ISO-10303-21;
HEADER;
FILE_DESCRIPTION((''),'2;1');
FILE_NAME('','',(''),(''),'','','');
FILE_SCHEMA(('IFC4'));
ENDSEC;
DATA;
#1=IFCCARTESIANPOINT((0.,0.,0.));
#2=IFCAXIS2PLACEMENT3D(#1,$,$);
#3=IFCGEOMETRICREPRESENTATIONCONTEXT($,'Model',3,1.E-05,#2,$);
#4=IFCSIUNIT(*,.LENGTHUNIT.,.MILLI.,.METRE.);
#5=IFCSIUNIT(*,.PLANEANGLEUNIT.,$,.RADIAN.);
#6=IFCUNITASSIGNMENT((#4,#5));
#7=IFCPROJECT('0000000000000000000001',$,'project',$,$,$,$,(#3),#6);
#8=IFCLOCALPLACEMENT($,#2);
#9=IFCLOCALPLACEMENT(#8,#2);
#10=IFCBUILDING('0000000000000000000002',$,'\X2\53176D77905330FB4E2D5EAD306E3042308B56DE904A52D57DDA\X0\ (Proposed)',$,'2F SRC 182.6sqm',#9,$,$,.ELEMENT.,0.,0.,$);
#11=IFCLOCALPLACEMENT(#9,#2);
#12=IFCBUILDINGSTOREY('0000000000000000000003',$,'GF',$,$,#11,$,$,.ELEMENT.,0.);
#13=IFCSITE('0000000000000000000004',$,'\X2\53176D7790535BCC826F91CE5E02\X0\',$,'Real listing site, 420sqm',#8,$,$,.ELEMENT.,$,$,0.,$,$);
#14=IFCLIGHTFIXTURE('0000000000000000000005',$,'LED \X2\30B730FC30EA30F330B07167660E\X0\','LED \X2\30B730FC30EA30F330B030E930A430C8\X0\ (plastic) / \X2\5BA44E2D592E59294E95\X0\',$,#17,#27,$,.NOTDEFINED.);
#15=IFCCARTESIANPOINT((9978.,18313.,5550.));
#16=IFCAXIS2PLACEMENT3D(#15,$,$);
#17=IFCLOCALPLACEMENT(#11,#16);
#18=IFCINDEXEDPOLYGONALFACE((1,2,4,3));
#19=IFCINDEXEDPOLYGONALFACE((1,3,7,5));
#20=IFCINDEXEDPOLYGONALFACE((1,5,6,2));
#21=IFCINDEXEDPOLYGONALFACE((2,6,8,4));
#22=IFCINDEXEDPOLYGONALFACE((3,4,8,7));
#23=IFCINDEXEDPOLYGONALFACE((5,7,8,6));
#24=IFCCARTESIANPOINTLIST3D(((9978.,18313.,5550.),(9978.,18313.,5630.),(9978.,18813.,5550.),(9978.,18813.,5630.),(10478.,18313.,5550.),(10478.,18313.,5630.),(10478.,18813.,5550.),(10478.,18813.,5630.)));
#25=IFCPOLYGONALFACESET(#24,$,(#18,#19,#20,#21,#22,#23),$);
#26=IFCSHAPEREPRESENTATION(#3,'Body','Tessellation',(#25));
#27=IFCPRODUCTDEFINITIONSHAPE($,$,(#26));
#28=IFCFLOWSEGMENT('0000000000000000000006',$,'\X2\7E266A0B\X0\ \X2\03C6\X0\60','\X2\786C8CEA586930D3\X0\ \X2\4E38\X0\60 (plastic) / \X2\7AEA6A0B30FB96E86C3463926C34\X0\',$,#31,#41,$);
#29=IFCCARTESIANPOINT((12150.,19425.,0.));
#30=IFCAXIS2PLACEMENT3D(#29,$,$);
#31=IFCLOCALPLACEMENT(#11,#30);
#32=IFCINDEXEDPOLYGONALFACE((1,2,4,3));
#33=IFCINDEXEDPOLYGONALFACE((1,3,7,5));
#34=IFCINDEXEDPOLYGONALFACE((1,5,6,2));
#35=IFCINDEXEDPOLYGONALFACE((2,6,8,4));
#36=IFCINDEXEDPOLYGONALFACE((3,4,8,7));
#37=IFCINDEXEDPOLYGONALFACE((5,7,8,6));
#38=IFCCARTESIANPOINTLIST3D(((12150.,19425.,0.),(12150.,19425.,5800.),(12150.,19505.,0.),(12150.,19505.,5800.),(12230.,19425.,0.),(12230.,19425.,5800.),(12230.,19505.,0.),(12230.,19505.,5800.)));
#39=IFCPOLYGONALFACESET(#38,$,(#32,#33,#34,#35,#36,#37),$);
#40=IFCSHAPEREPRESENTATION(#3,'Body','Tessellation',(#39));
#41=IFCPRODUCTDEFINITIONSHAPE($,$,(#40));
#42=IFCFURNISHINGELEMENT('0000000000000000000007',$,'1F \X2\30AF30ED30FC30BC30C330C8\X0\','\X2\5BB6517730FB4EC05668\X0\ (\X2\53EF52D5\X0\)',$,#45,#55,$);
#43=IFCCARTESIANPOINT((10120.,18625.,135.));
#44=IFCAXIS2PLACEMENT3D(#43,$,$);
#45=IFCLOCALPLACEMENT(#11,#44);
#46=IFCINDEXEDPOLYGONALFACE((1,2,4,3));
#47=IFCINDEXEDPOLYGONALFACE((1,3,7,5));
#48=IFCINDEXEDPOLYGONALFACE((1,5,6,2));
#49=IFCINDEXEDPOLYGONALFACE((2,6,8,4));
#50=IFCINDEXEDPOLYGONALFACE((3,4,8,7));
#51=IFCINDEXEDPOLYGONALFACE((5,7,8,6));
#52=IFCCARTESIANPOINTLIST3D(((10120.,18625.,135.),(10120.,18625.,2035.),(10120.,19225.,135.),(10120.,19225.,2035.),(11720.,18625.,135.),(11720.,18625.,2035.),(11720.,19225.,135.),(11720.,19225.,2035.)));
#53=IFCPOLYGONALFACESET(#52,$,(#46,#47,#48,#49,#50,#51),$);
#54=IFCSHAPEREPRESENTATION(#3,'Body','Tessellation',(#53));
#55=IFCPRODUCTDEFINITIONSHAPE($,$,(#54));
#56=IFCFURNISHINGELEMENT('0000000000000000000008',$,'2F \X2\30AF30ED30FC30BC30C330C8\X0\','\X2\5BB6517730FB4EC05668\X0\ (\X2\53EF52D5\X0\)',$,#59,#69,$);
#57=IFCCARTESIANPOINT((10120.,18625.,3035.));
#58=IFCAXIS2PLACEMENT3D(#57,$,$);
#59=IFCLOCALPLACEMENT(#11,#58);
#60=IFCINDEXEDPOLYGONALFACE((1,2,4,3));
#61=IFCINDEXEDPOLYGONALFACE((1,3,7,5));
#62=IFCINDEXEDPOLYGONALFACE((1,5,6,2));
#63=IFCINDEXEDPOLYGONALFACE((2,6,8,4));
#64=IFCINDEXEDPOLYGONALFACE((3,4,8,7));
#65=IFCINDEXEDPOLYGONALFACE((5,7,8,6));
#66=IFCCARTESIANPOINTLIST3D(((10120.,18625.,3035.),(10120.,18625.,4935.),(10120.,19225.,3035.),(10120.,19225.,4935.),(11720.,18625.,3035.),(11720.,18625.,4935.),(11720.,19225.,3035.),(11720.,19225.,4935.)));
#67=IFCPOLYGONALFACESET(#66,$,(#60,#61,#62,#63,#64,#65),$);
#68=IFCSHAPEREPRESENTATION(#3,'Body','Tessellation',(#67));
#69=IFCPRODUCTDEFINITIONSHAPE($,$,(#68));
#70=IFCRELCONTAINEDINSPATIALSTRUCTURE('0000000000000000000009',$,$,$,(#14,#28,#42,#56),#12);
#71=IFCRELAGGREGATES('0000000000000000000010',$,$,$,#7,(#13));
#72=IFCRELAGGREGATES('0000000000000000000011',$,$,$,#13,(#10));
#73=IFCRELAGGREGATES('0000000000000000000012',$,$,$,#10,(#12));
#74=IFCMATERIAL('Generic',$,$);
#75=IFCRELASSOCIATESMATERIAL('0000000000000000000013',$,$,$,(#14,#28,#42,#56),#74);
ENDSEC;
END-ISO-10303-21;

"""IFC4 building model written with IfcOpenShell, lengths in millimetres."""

from ifc_helpers import new_model, si_unit, frame, frame_2d, origin, place, context, project, spatial, rectangle, extrude, material, element, save


model = new_model("IFC4")

# Units and contexts
model_context = context("Model", 3, precision=1e-05, world=origin())
ifc_project = project(units=[si_unit("LENGTHUNIT", "METRE", prefix="MILLI"), si_unit("PLANEANGLEUNIT", "RADIAN")], contexts=[model_context])

# Site, building, storey
site_placement = place(None, origin())
site = spatial("IfcSite", under=ifc_project, at=site_placement, Name="北海道富良野市", ObjectType="Real listing site, 420sqm", CompositionType="ELEMENT", RefElevation=0.0)
building_placement = place(site_placement, origin())
building = spatial("IfcBuilding", under=site, at=building_placement, Name="北海道・中庭のある回遊動線 (Proposed)", ObjectType="2F SRC 182.6sqm", CompositionType="ELEMENT", ElevationOfRefHeight=0.0, ElevationOfTerrain=0.0)
storey_placement = place(building_placement, origin())
storey = spatial("IfcBuildingStorey", under=building, at=storey_placement, Name="GF", CompositionType="ELEMENT", Elevation=0.0)

# Shared definitions
ifc_material_1 = material(Name="Generic")

# Light fixture
light_fixture_1_placement = place(storey_placement, frame((9978.0, 18313.0, 5550.0)))
element("IfcLightFixture", 1, at=light_fixture_1_placement, inside=storey, material=ifc_material_1, Name="LED シーリング照明", Description="LED シーリングライト (plastic) / 室中央天井", PredefinedType="NOTDEFINED", context=model_context, shape_type="SweptSolid", body=[
    extrude(rectangle(XDim=500.0, YDim=500.0, at=frame_2d((250.0, 250.0))), frame((9978.0, 18313.0, 5550.0)), (0.0, 0.0, 1.0), 80.0),
])

# Flow segment
flow_segment_placement = place(storey_placement, frame((12150.0, 19425.0, 0.0)))
element("IfcFlowSegment", 2, at=flow_segment_placement, inside=storey, material=ifc_material_1, Name="縦樋 φ60", Description="硬質塩ビ 丸60 (plastic) / 竪樋・雨水排水", context=model_context, shape_type="SweptSolid", body=[
    extrude(rectangle(XDim=80.0, YDim=80.0, at=frame_2d((40.0, 40.0))), frame((12150.0, 19425.0, 0.0)), (0.0, 0.0, 1.0), 5800.0),
])

# Furnishing elements
furnishing_1_placement = place(storey_placement, frame((10120.0, 18625.0, 135.0)))
element("IfcFurnishingElement", 3, at=furnishing_1_placement, inside=storey, material=ifc_material_1, Name="1F クローゼット", Description="家具・什器 (可動)", context=model_context, shape_type="SweptSolid", body=[
    extrude(rectangle(XDim=1600.0, YDim=600.0, at=frame_2d((800.0, 300.0))), frame((10120.0, 18625.0, 135.0)), (0.0, 0.0, 1.0), 1900.0),
])
furnishing_2_placement = place(storey_placement, frame((10120.0, 18625.0, 3035.0)))
element("IfcFurnishingElement", 4, at=furnishing_2_placement, inside=storey, material=ifc_material_1, Name="2F クローゼット", Description="家具・什器 (可動)", context=model_context, shape_type="SweptSolid", body=[
    extrude(rectangle(XDim=1600.0, YDim=600.0, at=frame_2d((800.0, 300.0))), frame((10120.0, 18625.0, 3035.0)), (0.0, 0.0, 1.0), 1900.0),
])

save(model, "model.ifc")
